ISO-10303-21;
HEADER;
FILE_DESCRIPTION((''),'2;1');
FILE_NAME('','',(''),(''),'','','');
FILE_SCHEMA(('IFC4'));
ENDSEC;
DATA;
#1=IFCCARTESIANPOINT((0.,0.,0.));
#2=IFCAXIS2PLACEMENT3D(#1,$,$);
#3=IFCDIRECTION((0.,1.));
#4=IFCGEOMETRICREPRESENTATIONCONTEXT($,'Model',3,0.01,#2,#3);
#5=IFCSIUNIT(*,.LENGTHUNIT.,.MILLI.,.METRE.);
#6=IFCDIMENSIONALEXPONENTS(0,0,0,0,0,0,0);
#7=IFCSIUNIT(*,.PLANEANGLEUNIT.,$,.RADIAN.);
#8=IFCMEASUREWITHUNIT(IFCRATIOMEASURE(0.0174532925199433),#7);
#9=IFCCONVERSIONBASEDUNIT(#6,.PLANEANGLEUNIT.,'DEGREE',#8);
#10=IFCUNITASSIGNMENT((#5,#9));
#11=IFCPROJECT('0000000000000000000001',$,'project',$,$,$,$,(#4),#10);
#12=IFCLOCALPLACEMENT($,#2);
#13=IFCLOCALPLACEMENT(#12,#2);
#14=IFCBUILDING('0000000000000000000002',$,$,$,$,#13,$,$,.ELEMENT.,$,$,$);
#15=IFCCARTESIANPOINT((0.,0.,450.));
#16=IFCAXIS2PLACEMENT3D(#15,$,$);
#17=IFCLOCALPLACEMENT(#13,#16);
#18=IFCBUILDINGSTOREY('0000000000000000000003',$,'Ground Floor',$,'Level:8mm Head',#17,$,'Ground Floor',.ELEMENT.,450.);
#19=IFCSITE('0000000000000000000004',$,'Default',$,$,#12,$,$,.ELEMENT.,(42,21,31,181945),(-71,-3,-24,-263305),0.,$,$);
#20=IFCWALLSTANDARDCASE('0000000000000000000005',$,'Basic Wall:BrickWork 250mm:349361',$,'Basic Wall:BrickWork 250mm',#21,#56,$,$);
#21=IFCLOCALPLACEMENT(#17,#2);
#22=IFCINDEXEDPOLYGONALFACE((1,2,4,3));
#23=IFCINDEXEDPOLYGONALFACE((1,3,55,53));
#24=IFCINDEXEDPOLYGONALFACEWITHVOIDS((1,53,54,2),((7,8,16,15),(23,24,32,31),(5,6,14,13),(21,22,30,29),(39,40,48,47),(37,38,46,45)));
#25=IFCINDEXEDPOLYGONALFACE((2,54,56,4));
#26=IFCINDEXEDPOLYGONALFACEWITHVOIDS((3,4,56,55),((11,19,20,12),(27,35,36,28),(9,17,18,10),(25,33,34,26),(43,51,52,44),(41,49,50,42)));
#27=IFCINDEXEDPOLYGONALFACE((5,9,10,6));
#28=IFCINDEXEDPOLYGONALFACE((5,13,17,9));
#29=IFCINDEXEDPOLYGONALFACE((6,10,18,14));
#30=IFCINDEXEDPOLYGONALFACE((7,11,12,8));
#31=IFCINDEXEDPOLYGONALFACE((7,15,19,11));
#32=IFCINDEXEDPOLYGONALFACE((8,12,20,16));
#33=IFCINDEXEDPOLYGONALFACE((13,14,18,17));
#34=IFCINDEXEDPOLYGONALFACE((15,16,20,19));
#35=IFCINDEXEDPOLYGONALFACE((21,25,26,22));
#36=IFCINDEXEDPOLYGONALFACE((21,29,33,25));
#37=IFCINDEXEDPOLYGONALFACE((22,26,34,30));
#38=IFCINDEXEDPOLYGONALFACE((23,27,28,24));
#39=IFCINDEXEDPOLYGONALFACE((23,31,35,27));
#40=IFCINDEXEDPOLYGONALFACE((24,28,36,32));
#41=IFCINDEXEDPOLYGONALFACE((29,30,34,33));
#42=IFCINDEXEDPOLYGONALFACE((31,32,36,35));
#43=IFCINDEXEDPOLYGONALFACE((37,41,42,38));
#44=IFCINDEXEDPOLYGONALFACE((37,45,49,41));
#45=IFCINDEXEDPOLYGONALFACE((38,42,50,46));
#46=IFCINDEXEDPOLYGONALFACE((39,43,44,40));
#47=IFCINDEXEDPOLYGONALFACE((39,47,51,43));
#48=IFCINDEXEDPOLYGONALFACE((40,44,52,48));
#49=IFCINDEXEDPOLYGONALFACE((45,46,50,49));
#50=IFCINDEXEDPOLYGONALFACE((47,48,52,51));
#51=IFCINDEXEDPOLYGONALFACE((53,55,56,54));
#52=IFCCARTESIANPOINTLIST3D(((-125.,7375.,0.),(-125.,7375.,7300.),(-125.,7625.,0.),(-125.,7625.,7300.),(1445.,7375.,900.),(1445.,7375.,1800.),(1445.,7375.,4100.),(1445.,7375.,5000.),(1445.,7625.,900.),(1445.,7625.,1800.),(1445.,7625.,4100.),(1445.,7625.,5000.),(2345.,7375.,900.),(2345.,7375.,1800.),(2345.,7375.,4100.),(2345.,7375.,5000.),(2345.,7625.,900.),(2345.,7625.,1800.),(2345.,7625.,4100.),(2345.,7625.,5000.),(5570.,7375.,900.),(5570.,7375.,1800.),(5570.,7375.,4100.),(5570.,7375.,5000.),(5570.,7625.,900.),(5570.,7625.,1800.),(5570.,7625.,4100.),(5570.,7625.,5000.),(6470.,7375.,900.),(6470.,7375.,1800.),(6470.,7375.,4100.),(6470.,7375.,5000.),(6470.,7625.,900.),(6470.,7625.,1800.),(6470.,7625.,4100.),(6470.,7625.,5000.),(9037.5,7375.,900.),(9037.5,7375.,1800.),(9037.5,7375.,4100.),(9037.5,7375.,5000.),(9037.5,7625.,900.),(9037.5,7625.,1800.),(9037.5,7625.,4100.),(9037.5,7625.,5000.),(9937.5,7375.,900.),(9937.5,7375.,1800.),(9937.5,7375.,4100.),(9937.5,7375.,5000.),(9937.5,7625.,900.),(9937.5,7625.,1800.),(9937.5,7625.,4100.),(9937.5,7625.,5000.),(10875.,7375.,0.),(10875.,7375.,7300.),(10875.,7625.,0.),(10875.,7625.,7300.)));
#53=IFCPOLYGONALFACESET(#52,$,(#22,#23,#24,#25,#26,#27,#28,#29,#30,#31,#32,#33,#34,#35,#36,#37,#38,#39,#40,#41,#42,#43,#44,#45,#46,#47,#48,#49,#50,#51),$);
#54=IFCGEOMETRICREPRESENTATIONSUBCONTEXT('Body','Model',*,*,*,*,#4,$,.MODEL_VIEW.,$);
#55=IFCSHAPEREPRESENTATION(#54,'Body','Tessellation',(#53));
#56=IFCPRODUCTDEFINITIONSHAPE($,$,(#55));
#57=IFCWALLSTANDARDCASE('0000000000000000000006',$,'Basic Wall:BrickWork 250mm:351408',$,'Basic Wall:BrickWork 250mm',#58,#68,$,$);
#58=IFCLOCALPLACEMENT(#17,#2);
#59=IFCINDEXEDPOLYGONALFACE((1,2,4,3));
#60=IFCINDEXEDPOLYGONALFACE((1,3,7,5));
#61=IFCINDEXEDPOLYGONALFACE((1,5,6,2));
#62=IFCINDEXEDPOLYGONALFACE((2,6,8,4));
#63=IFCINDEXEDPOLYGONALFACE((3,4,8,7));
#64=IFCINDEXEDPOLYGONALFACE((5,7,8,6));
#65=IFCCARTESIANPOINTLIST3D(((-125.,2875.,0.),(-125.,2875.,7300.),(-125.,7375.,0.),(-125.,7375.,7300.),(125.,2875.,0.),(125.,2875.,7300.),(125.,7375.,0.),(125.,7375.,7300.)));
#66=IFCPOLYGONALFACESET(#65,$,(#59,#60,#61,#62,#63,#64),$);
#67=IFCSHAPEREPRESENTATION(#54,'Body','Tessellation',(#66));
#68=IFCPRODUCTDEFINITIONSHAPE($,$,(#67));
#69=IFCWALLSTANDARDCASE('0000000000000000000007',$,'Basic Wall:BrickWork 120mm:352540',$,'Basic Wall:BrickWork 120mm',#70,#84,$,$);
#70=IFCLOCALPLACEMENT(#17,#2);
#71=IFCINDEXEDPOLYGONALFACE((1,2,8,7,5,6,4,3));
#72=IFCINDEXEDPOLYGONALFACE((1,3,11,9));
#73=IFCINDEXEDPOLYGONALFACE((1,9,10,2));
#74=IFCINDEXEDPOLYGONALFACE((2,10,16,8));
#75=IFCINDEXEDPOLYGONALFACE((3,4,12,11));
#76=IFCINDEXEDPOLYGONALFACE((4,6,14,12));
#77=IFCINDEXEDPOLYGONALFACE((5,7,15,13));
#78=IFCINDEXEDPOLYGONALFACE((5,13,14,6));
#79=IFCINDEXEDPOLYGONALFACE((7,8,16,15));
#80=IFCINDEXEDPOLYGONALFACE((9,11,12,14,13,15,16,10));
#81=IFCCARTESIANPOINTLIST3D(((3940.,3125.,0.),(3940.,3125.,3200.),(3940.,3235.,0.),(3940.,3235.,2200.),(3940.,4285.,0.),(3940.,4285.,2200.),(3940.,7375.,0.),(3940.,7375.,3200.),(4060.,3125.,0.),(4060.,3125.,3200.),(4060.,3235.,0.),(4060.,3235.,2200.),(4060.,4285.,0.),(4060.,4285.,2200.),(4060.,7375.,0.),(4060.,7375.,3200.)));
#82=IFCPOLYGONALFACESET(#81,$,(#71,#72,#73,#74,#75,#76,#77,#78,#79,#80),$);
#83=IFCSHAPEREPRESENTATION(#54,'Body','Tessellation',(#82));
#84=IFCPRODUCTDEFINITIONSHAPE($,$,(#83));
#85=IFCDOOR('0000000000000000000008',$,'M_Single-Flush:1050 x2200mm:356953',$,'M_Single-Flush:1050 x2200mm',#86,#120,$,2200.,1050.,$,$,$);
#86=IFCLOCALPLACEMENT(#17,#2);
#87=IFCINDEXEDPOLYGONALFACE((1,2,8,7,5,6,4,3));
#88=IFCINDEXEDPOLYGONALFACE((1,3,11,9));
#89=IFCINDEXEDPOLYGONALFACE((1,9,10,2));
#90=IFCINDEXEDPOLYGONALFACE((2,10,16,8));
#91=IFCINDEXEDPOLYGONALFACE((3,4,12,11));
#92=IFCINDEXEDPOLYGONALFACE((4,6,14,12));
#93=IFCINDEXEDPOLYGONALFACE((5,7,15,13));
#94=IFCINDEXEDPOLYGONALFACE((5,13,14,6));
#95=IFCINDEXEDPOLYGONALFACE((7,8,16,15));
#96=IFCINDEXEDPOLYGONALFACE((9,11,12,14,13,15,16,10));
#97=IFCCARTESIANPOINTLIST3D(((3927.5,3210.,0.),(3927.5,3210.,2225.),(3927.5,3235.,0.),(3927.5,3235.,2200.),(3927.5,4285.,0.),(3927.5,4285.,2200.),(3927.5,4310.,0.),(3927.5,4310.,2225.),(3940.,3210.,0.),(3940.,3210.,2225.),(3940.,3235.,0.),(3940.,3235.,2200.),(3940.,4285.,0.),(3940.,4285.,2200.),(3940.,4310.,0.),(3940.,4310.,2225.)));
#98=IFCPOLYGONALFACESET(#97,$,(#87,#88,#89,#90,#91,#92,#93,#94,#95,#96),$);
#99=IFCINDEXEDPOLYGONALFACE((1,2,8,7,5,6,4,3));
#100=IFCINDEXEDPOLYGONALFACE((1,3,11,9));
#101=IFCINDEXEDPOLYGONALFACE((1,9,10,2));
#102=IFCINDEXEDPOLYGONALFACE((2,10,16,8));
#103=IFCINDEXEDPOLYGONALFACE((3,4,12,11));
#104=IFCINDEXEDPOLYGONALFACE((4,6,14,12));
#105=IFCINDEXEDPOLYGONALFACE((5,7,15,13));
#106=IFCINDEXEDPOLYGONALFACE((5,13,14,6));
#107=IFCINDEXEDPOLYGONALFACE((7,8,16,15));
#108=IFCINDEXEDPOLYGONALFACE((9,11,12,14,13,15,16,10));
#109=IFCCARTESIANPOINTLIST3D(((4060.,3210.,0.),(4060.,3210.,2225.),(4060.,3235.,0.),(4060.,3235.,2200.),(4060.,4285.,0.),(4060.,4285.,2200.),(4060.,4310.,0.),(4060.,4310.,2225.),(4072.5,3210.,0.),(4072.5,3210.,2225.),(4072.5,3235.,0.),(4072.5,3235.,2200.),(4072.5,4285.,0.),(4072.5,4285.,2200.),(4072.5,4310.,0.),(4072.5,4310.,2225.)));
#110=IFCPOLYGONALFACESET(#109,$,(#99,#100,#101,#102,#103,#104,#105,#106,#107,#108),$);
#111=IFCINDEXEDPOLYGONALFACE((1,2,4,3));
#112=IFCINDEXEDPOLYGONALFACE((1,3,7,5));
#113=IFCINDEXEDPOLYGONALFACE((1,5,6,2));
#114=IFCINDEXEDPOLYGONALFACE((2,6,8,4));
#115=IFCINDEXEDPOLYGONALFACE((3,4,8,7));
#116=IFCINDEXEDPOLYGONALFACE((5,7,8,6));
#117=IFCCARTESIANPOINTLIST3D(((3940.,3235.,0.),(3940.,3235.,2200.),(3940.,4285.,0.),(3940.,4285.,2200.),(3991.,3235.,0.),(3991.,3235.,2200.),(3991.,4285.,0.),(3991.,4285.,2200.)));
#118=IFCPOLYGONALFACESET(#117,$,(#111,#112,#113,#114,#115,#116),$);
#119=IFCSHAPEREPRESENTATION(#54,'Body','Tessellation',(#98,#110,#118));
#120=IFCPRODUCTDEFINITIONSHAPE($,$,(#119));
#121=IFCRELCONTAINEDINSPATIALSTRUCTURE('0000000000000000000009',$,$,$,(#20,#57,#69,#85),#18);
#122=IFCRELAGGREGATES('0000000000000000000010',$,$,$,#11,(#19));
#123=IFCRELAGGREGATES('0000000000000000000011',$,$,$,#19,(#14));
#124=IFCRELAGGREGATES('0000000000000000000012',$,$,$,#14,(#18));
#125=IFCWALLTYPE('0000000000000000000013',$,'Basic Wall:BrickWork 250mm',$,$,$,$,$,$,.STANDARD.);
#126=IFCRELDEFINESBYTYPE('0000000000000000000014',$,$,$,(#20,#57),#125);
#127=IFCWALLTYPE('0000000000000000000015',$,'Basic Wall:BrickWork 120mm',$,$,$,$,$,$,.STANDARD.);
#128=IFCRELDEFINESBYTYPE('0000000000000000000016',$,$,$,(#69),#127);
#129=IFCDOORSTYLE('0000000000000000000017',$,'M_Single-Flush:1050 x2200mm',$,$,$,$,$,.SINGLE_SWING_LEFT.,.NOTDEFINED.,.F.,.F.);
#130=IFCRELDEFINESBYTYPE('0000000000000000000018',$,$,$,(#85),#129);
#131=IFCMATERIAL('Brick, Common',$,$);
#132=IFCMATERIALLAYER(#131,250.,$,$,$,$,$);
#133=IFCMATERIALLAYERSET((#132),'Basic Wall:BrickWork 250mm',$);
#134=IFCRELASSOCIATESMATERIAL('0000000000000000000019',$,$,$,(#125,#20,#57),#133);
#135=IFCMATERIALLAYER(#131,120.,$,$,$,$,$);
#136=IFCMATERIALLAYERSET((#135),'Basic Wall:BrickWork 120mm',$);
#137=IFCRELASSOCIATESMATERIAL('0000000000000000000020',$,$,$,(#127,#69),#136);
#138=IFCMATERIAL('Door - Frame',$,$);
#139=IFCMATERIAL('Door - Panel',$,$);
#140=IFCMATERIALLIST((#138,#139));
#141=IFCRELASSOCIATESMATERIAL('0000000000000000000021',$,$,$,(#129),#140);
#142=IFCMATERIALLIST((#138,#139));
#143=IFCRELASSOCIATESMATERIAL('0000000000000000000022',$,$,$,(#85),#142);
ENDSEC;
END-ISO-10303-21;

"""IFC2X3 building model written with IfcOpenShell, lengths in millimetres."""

from ifc_helpers import new_model, entity, si_unit, converted_unit, direction, frame, frame_2d, origin, place, context, subcontext, project, spatial, polyline, rectangle, outline, extrude, source, transform, mapped, material, material_list, layer, layer_set, layer_usage, type_object, type_shapes, element, fill, save


model = new_model("IFC2X3")

# Units and contexts
model_context = context("Model", 3, precision=0.01, world=origin(), true_north=direction((0.0, 1.0)))
body_context = subcontext(model_context, "Body", "Model", "MODEL_VIEW")
ifc_project = project(units=[si_unit("LENGTHUNIT", "METRE", prefix="MILLI"), converted_unit("PLANEANGLEUNIT", "DEGREE", entity("IfcRatioMeasure", 0.0174532925199433), si_unit("PLANEANGLEUNIT", "RADIAN"), dimensions=[0, 0, 0, 0, 0, 0, 0])], contexts=[model_context])

# Site, building, storey
site_placement = place(None, origin())
site = spatial("IfcSite", under=ifc_project, at=site_placement, Name="Default", CompositionType="ELEMENT", RefLatitude=(42, 21, 31, 181945), RefLongitude=(-71, -3, -24, -263305), RefElevation=0.0)
building_placement = place(site_placement, origin())
building = spatial("IfcBuilding", under=site, at=building_placement, CompositionType="ELEMENT")
storey_placement = place(building_placement, frame((0.0, 0.0, 450.0)))
storey = spatial("IfcBuildingStorey", under=building, at=storey_placement, Name="Ground Floor", ObjectType="Level:8mm Head", LongName="Ground Floor", CompositionType="ELEMENT", Elevation=450.0)

# Wall, openings
ifc_material_1 = material(Name="Brick, Common")
ifc_layer_1 = layer(ifc_material_1, 250.0)
ifc_layer_set_1 = layer_set([ifc_layer_1], Name="Basic Wall:BrickWork 250mm")
ifc_layer_usage_1 = layer_usage(ifc_layer_set_1, "AXIS2", "POSITIVE", -125.0)
wall_type_1 = type_object("IfcWallType", Name="Basic Wall:BrickWork 250mm", PredefinedType="STANDARD", material=ifc_layer_set_1)
wall_1_placement = place(storey_placement, frame((-125.0, 7500.0, 0.0)))
wall_1 = element("IfcWallStandardCase", 1, at=wall_1_placement, inside=storey, type_object=wall_type_1, material=ifc_layer_usage_1, Name="Basic Wall:BrickWork 250mm:349361", ObjectType="Basic Wall:BrickWork 250mm", context=body_context, shape_type="SweptSolid", body=[
    extrude(rectangle(XDim=11000.0, YDim=250.0, at=frame_2d((5500.0, 0.0), x_axis=(-1.0, 0.0))), origin(), (0.0, 0.0, 1.0), 7300.0),
])
opening_1_placement = place(wall_1_placement, frame((2470.0, 125.0, 900.0)))
element("IfcOpeningElement", 2, at=opening_1_placement, cuts=wall_1, ObjectType="Opening", context=body_context, shape_type="SweptSolid", body=[
    extrude(rectangle(XDim=900.0, YDim=900.0, at=frame_2d((450.0, 450.0), x_axis=(-1.0, 0.0))), frame((0.0, 0.0, 0.0), z_axis=(0.0, -1.0, 0.0), x_axis=(0.0, 0.0, 1.0)), (0.0, 0.0, 1.0), 250.0),
])
opening_2_placement = place(wall_1_placement, frame((6595.0, 125.0, 900.0)))
element("IfcOpeningElement", 3, at=opening_2_placement, cuts=wall_1, ObjectType="Opening", context=body_context, shape_type="SweptSolid", body=[
    extrude(rectangle(XDim=900.0, YDim=900.0, at=frame_2d((450.0, 450.0), x_axis=(-1.0, 0.0))), frame((0.0, 0.0, 0.0), z_axis=(0.0, -1.0, 0.0), x_axis=(0.0, 0.0, 1.0)), (0.0, 0.0, 1.0), 250.0),
])
opening_3_placement = place(wall_1_placement, frame((10062.5, 125.0, 900.0)))
element("IfcOpeningElement", 4, at=opening_3_placement, cuts=wall_1, ObjectType="Opening", context=body_context, shape_type="SweptSolid", body=[
    extrude(rectangle(XDim=900.0, YDim=900.0, at=frame_2d((450.0, 450.0), x_axis=(-1.0, 0.0))), frame((0.0, 0.0, 0.0), z_axis=(0.0, -1.0, 0.0), x_axis=(0.0, 0.0, 1.0)), (0.0, 0.0, 1.0), 250.0),
])
opening_4_placement = place(wall_1_placement, frame((2470.0, 125.0, 4100.0)))
element("IfcOpeningElement", 5, at=opening_4_placement, cuts=wall_1, ObjectType="Opening", context=body_context, shape_type="SweptSolid", body=[
    extrude(rectangle(XDim=900.0, YDim=900.0, at=frame_2d((450.0, 450.0), x_axis=(-1.0, 0.0))), frame((0.0, 0.0, 0.0), z_axis=(0.0, -1.0, 0.0), x_axis=(0.0, 0.0, 1.0)), (0.0, 0.0, 1.0), 250.0),
])
opening_5_placement = place(wall_1_placement, frame((6595.0, 125.0, 4100.0)))
element("IfcOpeningElement", 6, at=opening_5_placement, cuts=wall_1, ObjectType="Opening", context=body_context, shape_type="SweptSolid", body=[
    extrude(rectangle(XDim=900.0, YDim=900.0, at=frame_2d((450.0, 450.0), x_axis=(-1.0, 0.0))), frame((0.0, 0.0, 0.0), z_axis=(0.0, -1.0, 0.0), x_axis=(0.0, 0.0, 1.0)), (0.0, 0.0, 1.0), 250.0),
])
opening_6_placement = place(wall_1_placement, frame((10062.5, 125.0, 4100.0)))
element("IfcOpeningElement", 7, at=opening_6_placement, cuts=wall_1, ObjectType="Opening", context=body_context, shape_type="SweptSolid", body=[
    extrude(rectangle(XDim=900.0, YDim=900.0, at=frame_2d((450.0, 450.0), x_axis=(-1.0, 0.0))), frame((0.0, 0.0, 0.0), z_axis=(0.0, -1.0, 0.0), x_axis=(0.0, 0.0, 1.0)), (0.0, 0.0, 1.0), 250.0),
])

# Wall
ifc_layer_usage_2 = layer_usage(ifc_layer_set_1, "AXIS2", "POSITIVE", -125.0)
wall_2_placement = place(storey_placement, frame((0.0, 7375.0, 0.0), z_axis=(0.0, 0.0, 1.0), x_axis=(0.0, -1.0, 0.0)))
element("IfcWallStandardCase", 8, at=wall_2_placement, inside=storey, type_object=wall_type_1, material=ifc_layer_usage_2, Name="Basic Wall:BrickWork 250mm:351408", ObjectType="Basic Wall:BrickWork 250mm", context=body_context, shape_type="SweptSolid", body=[
    extrude(rectangle(XDim=4500.0, YDim=250.0, at=frame_2d((2250.0, 0.0), x_axis=(-1.0, 0.0))), origin(), (0.0, 0.0, 1.0), 7300.0),
])

# Wall, opening, door
ifc_layer_2 = layer(ifc_material_1, 120.0)
ifc_layer_set_2 = layer_set([ifc_layer_2], Name="Basic Wall:BrickWork 120mm")
ifc_layer_usage_3 = layer_usage(ifc_layer_set_2, "AXIS2", "NEGATIVE", 60.0)
wall_type_2 = type_object("IfcWallType", Name="Basic Wall:BrickWork 120mm", PredefinedType="STANDARD", material=ifc_layer_set_2)
wall_3_placement = place(storey_placement, frame((4000.0, 7375.0, 0.0), z_axis=(0.0, 0.0, 1.0), x_axis=(0.0, -1.0, 0.0)))
wall_3 = element("IfcWallStandardCase", 9, at=wall_3_placement, inside=storey, type_object=wall_type_2, material=ifc_layer_usage_3, Name="Basic Wall:BrickWork 120mm:352540", ObjectType="Basic Wall:BrickWork 120mm", context=body_context, shape_type="SweptSolid", body=[
    extrude(rectangle(XDim=4250.0, YDim=120.0, at=frame_2d((2125.0, 0.0), x_axis=(-1.0, 0.0))), origin(), (0.0, 0.0, 1.0), 3200.0),
])
opening_7_placement = place(wall_3_placement, frame((4140.0, 60.0, 0.0)))
opening_7 = element("IfcOpeningElement", 10, at=opening_7_placement, cuts=wall_3, ObjectType="Opening", context=body_context, shape_type="SweptSolid", body=[
    extrude(rectangle(XDim=1050.0, YDim=2200.0, at=frame_2d((1100.0, 525.0), x_axis=(0.0, -1.0))), frame((0.0, 0.0, 0.0), z_axis=(0.0, -1.0, 0.0), x_axis=(0.0, 0.0, 1.0)), (0.0, 0.0, 1.0), 120.0),
])
ifc_material_2 = material(Name="Door - Frame")
ifc_material_3 = material(Name="Door - Panel")
ifc_material_list_1 = material_list([ifc_material_2, ifc_material_3])
ifc_material_list_2 = material_list([ifc_material_2, ifc_material_3])
door_style = type_object("IfcDoorStyle", Name="M_Single-Flush:1050 x2200mm", ConstructionType="NOTDEFINED", OperationType="SINGLE_SWING_LEFT", ParameterTakesPrecedence=False, Sizeable=False, material=ifc_material_list_2)
shared_shape_1 = source(origin(), body_context, "Body", "SweptSolid", [
    extrude(outline(polyline([(-550.0, -1118.8), (550.0, -1118.8), (550.0, 1106.2), (525.0, 1106.2), (525.0, -1093.8), (-525.0, -1093.8), (-525.0, 1106.2), (-550.0, 1106.2), (-550.0, -1118.8)])), frame((525.0, 132.5, 1106.2), z_axis=(0.0, -1.0, 0.0), x_axis=(-1.0, 0.0, 0.0)), (0.0, 0.0, 1.0), 12.5),
    extrude(outline(polyline([(-1118.8, -550.0), (1106.2, -550.0), (1106.2, -525.0), (-1093.8, -525.0), (-1093.8, 525.0), (1106.2, 525.0), (1106.2, 550.0), (-1118.8, 550.0), (-1118.8, -550.0)])), frame((525.0, 0.0, 1106.2), z_axis=(0.0, -1.0, 0.0), x_axis=(0.0, 0.0, -1.0)), (0.0, 0.0, 1.0), 12.5),
    extrude(rectangle(XDim=1050.0, YDim=51.0, at=frame_2d((0.0, 0.0), x_axis=(1.0, 0.0))), frame((525.0, 94.5, 0.0)), (0.0, 0.0, 1.0), 2200.0),
])
type_shapes(door_style, [shared_shape_1])
door_placement = place(opening_7_placement, frame((0.0, 0.0, 0.0), z_axis=(0.0, 0.0, 1.0), x_axis=(-1.0, 0.0, 0.0)))
door = element("IfcDoor", 11, at=door_placement, inside=storey, type_object=door_style, material=ifc_material_list_1, Name="M_Single-Flush:1050 x2200mm:356953", ObjectType="M_Single-Flush:1050 x2200mm", OverallHeight=2200.0, OverallWidth=1050.0, context=body_context, shape_type="MappedRepresentation", body=[
    mapped(shared_shape_1, transform((0.0, 0.0, 0.0), scale=1.0)),
])
fill(opening_7, door)

save(model, "model.ifc")
